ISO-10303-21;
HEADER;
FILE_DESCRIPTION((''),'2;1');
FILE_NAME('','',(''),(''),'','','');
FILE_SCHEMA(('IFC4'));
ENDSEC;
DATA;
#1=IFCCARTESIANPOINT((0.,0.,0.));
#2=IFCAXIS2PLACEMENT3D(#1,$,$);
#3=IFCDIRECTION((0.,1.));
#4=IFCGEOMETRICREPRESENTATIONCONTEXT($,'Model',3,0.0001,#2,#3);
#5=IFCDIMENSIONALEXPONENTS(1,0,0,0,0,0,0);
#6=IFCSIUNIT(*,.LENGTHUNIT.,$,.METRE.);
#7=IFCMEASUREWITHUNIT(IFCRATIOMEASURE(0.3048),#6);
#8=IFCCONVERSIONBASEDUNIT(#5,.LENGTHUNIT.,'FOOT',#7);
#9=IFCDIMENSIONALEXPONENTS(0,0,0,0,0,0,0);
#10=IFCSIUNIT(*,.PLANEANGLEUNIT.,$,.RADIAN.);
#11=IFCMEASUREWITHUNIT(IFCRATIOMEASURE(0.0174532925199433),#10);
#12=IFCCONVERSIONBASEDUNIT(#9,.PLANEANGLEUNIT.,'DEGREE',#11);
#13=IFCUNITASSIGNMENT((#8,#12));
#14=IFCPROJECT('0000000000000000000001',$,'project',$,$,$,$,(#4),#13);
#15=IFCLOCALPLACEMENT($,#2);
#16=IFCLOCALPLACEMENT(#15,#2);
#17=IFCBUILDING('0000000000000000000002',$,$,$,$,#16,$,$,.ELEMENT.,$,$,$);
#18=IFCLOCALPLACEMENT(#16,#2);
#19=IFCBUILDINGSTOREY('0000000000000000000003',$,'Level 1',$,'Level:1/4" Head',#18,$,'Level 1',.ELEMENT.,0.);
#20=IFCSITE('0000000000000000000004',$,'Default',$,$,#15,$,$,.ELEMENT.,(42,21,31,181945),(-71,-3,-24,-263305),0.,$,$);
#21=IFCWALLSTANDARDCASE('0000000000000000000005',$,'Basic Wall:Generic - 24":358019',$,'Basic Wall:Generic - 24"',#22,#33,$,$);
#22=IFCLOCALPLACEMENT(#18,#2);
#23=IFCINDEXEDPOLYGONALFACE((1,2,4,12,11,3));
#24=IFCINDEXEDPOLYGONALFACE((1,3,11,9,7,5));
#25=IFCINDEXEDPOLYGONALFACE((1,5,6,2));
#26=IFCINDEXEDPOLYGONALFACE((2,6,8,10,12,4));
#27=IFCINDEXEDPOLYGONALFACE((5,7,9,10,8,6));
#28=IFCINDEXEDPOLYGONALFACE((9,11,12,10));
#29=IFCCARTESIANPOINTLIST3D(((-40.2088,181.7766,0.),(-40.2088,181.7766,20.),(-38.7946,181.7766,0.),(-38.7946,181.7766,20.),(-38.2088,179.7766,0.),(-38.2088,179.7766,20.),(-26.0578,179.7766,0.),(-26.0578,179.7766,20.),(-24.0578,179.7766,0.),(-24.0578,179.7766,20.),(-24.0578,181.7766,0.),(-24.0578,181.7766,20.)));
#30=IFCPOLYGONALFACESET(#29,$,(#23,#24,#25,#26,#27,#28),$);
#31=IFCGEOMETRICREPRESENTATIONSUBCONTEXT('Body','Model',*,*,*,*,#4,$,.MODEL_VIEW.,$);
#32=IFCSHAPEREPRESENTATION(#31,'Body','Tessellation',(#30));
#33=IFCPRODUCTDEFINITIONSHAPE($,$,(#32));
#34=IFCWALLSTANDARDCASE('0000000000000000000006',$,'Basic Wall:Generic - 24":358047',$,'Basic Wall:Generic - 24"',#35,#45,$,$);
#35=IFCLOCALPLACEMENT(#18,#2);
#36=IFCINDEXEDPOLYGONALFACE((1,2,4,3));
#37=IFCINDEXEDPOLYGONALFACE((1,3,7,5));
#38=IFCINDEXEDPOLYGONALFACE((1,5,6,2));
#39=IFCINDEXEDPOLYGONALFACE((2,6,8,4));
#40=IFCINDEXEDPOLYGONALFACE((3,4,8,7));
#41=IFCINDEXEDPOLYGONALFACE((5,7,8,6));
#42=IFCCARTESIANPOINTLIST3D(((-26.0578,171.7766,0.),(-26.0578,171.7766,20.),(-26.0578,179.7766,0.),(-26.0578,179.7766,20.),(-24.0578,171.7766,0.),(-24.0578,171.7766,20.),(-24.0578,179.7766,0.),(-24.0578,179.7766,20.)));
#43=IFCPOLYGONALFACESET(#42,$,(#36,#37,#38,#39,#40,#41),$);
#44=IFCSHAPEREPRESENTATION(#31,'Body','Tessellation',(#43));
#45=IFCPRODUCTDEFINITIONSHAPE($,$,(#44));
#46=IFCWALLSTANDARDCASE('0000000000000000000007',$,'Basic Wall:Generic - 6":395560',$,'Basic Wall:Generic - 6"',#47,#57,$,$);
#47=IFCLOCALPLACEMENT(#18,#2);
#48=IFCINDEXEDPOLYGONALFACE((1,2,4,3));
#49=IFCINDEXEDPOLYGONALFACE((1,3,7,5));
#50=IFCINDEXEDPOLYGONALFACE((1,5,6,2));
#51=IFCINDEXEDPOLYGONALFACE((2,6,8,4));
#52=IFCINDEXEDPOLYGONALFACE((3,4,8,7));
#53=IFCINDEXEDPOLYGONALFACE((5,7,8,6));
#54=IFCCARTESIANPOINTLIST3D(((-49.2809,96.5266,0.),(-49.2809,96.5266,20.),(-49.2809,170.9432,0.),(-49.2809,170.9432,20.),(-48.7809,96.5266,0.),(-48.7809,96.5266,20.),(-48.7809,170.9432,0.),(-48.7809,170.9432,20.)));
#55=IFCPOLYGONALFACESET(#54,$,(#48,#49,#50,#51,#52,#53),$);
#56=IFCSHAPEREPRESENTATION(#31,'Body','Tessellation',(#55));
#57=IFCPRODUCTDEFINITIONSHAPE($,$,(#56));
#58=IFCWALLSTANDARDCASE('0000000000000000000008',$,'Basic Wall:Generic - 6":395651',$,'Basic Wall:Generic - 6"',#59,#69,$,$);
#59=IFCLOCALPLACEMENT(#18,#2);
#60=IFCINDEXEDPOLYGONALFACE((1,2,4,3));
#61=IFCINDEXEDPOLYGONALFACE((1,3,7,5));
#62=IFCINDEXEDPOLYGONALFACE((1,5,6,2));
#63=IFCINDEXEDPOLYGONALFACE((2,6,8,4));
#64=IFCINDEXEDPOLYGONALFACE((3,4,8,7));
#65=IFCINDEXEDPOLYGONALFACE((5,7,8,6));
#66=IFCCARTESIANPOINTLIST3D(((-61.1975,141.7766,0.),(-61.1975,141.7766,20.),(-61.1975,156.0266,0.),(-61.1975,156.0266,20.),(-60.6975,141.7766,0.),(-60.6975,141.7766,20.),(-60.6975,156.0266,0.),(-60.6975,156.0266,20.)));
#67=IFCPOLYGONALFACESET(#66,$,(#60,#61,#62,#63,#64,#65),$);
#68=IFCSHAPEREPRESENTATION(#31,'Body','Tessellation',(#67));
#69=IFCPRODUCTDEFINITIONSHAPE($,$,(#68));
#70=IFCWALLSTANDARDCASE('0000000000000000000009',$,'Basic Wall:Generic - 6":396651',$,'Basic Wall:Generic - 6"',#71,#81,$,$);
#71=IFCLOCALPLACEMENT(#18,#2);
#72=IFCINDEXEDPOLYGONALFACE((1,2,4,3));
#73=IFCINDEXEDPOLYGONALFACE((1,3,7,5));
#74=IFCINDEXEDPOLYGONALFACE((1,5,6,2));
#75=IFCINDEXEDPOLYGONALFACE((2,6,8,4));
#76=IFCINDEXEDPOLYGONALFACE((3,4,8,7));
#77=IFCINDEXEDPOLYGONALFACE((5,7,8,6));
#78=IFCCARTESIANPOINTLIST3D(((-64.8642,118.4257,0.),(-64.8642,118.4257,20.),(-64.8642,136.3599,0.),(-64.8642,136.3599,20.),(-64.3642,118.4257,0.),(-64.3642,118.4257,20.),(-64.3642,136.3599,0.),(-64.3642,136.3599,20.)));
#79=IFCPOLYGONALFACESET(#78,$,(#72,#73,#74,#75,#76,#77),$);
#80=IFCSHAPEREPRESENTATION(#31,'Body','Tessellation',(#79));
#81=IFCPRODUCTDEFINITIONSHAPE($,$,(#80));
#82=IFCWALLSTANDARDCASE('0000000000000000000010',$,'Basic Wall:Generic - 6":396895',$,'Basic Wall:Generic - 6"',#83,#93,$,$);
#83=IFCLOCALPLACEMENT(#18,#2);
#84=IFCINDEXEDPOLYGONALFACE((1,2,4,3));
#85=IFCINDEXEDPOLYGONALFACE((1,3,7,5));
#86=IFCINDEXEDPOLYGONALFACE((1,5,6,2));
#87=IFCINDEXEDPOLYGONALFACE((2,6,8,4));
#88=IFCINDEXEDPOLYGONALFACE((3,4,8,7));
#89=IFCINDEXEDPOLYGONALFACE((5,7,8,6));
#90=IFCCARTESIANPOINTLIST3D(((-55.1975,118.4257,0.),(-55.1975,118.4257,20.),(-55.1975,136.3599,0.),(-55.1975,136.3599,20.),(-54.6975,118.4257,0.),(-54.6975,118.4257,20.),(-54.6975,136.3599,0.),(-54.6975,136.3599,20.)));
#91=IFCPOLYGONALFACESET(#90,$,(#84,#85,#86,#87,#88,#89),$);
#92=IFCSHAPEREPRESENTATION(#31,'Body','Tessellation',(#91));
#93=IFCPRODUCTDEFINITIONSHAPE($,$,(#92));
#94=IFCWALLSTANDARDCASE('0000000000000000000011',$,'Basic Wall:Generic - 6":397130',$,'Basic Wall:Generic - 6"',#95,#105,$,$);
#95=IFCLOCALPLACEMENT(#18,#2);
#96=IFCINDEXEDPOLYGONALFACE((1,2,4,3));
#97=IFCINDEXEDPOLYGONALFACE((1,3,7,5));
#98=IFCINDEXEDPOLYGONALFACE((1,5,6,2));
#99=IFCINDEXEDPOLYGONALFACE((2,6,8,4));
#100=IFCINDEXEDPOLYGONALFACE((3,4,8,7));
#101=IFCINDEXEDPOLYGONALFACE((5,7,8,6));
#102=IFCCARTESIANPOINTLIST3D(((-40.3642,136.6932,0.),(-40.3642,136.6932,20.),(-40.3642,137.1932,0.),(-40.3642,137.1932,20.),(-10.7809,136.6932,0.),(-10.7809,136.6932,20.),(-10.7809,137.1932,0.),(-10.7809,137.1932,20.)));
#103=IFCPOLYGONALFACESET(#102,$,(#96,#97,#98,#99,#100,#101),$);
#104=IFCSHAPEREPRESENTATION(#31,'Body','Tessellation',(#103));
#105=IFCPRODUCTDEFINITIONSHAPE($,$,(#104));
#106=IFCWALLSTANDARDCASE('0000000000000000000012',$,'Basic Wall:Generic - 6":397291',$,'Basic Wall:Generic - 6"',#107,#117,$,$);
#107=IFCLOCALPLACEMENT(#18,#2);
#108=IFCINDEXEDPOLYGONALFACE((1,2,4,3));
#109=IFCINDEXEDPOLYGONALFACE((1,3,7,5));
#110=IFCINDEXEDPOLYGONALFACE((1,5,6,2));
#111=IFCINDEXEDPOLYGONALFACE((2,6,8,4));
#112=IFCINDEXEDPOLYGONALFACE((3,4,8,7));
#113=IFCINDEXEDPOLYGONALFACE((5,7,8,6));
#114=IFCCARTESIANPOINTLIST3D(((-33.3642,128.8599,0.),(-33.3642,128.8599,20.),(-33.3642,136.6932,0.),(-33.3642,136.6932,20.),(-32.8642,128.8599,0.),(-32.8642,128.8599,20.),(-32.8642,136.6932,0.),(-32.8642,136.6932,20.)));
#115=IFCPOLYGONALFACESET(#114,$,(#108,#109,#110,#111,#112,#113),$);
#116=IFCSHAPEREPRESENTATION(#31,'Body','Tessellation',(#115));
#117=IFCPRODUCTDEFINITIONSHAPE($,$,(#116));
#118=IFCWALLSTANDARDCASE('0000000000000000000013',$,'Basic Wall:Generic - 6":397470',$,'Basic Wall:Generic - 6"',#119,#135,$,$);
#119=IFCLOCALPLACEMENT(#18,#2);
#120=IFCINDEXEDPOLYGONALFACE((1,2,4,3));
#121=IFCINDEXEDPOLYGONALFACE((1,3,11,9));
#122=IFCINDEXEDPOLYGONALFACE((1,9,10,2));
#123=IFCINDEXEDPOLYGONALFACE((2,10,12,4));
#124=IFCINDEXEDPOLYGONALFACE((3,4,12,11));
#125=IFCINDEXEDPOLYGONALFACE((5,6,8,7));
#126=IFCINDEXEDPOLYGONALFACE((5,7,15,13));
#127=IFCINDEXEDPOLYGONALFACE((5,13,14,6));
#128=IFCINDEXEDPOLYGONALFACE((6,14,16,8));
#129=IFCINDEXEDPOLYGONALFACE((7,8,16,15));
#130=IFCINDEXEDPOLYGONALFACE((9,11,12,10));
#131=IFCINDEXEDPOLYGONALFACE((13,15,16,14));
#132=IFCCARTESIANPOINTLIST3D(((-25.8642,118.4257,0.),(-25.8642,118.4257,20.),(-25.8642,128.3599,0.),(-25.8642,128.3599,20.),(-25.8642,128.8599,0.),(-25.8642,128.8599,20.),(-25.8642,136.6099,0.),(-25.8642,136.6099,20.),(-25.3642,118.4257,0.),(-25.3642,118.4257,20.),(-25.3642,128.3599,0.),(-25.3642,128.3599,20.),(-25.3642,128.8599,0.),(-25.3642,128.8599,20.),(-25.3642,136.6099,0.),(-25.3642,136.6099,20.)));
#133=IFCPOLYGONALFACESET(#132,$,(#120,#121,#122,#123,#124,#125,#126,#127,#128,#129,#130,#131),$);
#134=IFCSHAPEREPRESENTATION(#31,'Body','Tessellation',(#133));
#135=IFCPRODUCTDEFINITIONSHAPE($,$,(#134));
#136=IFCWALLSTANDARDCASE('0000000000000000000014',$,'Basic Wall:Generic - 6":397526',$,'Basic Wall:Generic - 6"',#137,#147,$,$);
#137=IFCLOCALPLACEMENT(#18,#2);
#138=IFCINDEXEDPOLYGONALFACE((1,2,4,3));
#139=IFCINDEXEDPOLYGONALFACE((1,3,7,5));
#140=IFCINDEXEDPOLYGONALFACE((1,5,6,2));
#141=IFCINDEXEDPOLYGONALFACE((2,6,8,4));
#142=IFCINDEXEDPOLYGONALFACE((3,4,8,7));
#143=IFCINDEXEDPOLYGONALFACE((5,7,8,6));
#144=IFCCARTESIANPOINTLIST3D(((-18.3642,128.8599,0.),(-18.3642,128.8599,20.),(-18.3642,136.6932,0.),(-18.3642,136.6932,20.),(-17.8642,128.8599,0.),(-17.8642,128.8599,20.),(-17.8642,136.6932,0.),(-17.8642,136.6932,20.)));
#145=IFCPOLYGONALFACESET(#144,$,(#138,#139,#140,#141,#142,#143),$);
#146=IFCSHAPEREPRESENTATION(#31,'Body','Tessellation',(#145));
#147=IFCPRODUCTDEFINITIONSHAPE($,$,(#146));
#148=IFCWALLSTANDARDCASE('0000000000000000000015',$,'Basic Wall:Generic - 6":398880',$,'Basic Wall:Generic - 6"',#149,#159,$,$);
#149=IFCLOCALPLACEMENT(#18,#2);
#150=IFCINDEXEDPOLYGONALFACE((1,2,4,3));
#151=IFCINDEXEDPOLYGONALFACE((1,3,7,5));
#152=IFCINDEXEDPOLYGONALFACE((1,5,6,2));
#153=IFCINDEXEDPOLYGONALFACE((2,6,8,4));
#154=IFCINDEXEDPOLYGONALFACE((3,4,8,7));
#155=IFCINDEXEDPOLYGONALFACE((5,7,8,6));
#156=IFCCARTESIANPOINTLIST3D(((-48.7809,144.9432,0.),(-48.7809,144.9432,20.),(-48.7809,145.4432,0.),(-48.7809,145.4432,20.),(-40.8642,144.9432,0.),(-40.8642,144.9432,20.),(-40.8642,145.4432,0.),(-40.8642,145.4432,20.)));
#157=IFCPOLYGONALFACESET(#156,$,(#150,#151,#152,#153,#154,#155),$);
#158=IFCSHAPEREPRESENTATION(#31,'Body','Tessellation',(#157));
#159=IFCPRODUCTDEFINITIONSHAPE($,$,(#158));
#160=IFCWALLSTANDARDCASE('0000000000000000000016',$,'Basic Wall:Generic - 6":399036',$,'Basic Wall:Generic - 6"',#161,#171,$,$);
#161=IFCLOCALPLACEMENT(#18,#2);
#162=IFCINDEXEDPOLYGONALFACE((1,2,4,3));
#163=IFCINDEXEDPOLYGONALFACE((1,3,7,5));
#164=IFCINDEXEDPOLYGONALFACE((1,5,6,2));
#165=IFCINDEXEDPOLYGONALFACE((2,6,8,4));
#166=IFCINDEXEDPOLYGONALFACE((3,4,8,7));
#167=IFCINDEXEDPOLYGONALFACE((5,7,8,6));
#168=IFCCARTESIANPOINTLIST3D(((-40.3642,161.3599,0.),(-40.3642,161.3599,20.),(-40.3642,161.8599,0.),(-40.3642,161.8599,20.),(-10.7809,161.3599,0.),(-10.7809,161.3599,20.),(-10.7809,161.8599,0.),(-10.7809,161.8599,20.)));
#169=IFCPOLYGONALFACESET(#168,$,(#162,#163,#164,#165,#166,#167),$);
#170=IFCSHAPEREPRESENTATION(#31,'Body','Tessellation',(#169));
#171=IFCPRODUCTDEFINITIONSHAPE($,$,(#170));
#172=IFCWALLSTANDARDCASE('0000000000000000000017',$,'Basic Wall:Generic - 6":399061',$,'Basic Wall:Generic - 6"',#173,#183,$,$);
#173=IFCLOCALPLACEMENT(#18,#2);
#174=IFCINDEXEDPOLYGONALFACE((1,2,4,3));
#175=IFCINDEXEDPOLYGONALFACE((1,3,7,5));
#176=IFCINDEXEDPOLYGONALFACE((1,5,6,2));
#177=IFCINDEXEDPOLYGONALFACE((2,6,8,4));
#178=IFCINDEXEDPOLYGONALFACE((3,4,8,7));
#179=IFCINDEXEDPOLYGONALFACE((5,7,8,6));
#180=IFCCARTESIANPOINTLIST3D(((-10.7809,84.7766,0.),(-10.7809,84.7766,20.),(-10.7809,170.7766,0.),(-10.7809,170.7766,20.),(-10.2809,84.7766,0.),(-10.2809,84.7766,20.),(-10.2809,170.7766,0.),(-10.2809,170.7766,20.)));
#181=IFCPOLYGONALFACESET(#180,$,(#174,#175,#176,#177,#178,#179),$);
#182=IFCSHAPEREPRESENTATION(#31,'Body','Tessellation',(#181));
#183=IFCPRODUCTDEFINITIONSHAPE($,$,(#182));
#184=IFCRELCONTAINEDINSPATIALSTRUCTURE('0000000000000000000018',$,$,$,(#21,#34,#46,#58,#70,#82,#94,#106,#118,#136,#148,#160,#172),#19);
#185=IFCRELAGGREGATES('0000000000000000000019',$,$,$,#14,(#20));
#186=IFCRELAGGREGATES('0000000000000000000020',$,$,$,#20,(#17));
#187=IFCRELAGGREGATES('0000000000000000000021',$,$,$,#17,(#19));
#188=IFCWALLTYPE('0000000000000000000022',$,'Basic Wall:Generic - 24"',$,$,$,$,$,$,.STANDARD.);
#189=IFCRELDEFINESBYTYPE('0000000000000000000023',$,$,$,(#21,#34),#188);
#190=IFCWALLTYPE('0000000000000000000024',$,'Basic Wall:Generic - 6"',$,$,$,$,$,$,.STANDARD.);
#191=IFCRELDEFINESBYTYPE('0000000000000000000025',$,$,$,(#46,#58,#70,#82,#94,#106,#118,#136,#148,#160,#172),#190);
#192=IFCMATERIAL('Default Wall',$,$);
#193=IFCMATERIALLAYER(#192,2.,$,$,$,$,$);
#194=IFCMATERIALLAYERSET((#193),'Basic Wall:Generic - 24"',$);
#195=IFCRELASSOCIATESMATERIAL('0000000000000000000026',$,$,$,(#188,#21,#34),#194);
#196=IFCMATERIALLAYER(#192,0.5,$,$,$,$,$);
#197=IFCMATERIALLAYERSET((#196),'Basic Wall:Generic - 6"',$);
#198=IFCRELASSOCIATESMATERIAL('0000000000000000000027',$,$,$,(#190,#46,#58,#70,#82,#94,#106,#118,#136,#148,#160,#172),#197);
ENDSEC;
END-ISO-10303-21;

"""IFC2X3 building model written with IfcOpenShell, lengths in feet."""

from ifc_helpers import new_model, entity, si_unit, converted_unit, direction, frame, frame_2d, origin, origin_2d_with_axis, place, context, subcontext, project, spatial, polyline, rectangle, outline, extrude, material, layer, layer_set, layer_usage, type_object, element, save


model = new_model("IFC2X3")

# Units and contexts
model_context = context("Model", 3, precision=0.0001, world=origin(), true_north=direction((0.0, 1.0)))
body_context = subcontext(model_context, "Body", "Model", "MODEL_VIEW")
ifc_project = project(units=[converted_unit("LENGTHUNIT", "FOOT", entity("IfcRatioMeasure", 0.3048), si_unit("LENGTHUNIT", "METRE"), dimensions=[1, 0, 0, 0, 0, 0, 0]), converted_unit("PLANEANGLEUNIT", "DEGREE", entity("IfcRatioMeasure", 0.0174532925199433), si_unit("PLANEANGLEUNIT", "RADIAN"), dimensions=[0, 0, 0, 0, 0, 0, 0])], contexts=[model_context])

# Site, building, storey
site_placement = place(None, origin())
site = spatial("IfcSite", under=ifc_project, at=site_placement, Name="Default", CompositionType="ELEMENT", RefLatitude=(42, 21, 31, 181945), RefLongitude=(-71, -3, -24, -263305), RefElevation=0.0)
building_placement = place(site_placement, origin())
building = spatial("IfcBuilding", under=site, at=building_placement, CompositionType="ELEMENT")
storey_placement = place(building_placement, origin())
storey = spatial("IfcBuildingStorey", under=building, at=storey_placement, Name="Level 1", ObjectType="Level:1/4\" Head", LongName="Level 1", CompositionType="ELEMENT", Elevation=0.0)

# Walls
ifc_material = material(Name="Default Wall")
ifc_layer_1 = layer(ifc_material, 2.0)
ifc_layer_set_1 = layer_set([ifc_layer_1], Name="Basic Wall:Generic - 24\"")
ifc_layer_usage_1 = layer_usage(ifc_layer_set_1, "AXIS2", "NEGATIVE", 1.0)
wall_type_1 = type_object("IfcWallType", Name="Basic Wall:Generic - 24\"", PredefinedType="STANDARD", material=ifc_layer_set_1)
wall_1_placement = place(storey_placement, frame((-40.2088, 180.7766, 0.0)))
element("IfcWallStandardCase", 1, at=wall_1_placement, inside=storey, type_object=wall_type_1, material=ifc_layer_usage_1, Name="Basic Wall:Generic - 24\":358019", ObjectType="Basic Wall:Generic - 24\"", context=body_context, shape_type="SweptSolid", body=[
    extrude(outline(polyline([(16.151, -1.0), (16.151, 1.0), (1.4142, 1.0), (0.0, 1.0), (2.0, -1.0), (14.151, -1.0), (16.151, -1.0)])), origin(), (0.0, 0.0, 1.0), 20.0),
])
ifc_layer_usage_2 = layer_usage(ifc_layer_set_1, "AXIS2", "NEGATIVE", 1.0)
wall_2_placement = place(storey_placement, frame((-25.0578, 179.7766, 0.0), z_axis=(0.0, 0.0, 1.0), x_axis=(0.0, -1.0, 0.0)))
element("IfcWallStandardCase", 2, at=wall_2_placement, inside=storey, type_object=wall_type_1, material=ifc_layer_usage_2, Name="Basic Wall:Generic - 24\":358047", ObjectType="Basic Wall:Generic - 24\"", context=body_context, shape_type="SweptSolid", body=[
    extrude(rectangle(XDim=8.0, YDim=2.0, at=frame_2d((4.0, 0.0), x_axis=(-1.0, 0.0))), origin(), (0.0, 0.0, 1.0), 20.0),
])
ifc_layer_2 = layer(ifc_material, 0.5)
ifc_layer_set_2 = layer_set([ifc_layer_2], Name="Basic Wall:Generic - 6\"")
ifc_layer_usage_3 = layer_usage(ifc_layer_set_2, "AXIS2", "NEGATIVE", 0.25)
wall_type_2 = type_object("IfcWallType", Name="Basic Wall:Generic - 6\"", PredefinedType="STANDARD", material=ifc_layer_set_2)
wall_3_placement = place(storey_placement, frame((-49.0309, 170.9432, 0.0), z_axis=(0.0, 0.0, 1.0), x_axis=(0.0, -1.0, 0.0)))
element("IfcWallStandardCase", 3, at=wall_3_placement, inside=storey, type_object=wall_type_2, material=ifc_layer_usage_3, Name="Basic Wall:Generic - 6\":395560", ObjectType="Basic Wall:Generic - 6\"", context=body_context, shape_type="SweptSolid", body=[
    extrude(rectangle(XDim=74.4167, YDim=0.5, at=frame_2d((37.2083, 0.0), x_axis=(-1.0, 0.0))), origin(), (0.0, 0.0, 1.0), 20.0),
])
ifc_layer_usage_4 = layer_usage(ifc_layer_set_2, "AXIS2", "NEGATIVE", 0.25)
wall_4_placement = place(storey_placement, frame((-60.9475, 156.0266, 0.0), z_axis=(0.0, 0.0, 1.0), x_axis=(0.0, -1.0, 0.0)))
element("IfcWallStandardCase", 4, at=wall_4_placement, inside=storey, type_object=wall_type_2, material=ifc_layer_usage_4, Name="Basic Wall:Generic - 6\":395651", ObjectType="Basic Wall:Generic - 6\"", context=body_context, shape_type="SweptSolid", body=[
    extrude(rectangle(XDim=14.25, YDim=0.5, at=frame_2d((7.125, 0.0), x_axis=(-1.0, 0.0))), origin(), (0.0, 0.0, 1.0), 20.0),
])
ifc_layer_usage_5 = layer_usage(ifc_layer_set_2, "AXIS2", "NEGATIVE", 0.25)
wall_5_placement = place(storey_placement, frame((-64.6142, 136.3599, 0.0), z_axis=(0.0, 0.0, 1.0), x_axis=(0.0, -1.0, 0.0)))
element("IfcWallStandardCase", 5, at=wall_5_placement, inside=storey, type_object=wall_type_2, material=ifc_layer_usage_5, Name="Basic Wall:Generic - 6\":396651", ObjectType="Basic Wall:Generic - 6\"", context=body_context, shape_type="SweptSolid", body=[
    extrude(rectangle(XDim=17.9342, YDim=0.5, at=frame_2d((8.9671, 0.0), x_axis=(-1.0, 0.0))), origin(), (0.0, 0.0, 1.0), 20.0),
])
ifc_layer_usage_6 = layer_usage(ifc_layer_set_2, "AXIS2", "NEGATIVE", 0.25)
wall_6_placement = place(storey_placement, frame((-54.9475, 136.3599, 0.0), z_axis=(0.0, 0.0, 1.0), x_axis=(0.0, -1.0, 0.0)))
element("IfcWallStandardCase", 6, at=wall_6_placement, inside=storey, type_object=wall_type_2, material=ifc_layer_usage_6, Name="Basic Wall:Generic - 6\":396895", ObjectType="Basic Wall:Generic - 6\"", context=body_context, shape_type="SweptSolid", body=[
    extrude(rectangle(XDim=17.9342, YDim=0.5, at=frame_2d((8.9671, 0.0), x_axis=(-1.0, 0.0))), origin(), (0.0, 0.0, 1.0), 20.0),
])
ifc_layer_usage_7 = layer_usage(ifc_layer_set_2, "AXIS2", "NEGATIVE", 0.25)
wall_7_placement = place(storey_placement, frame((-40.3642, 136.9432, 0.0)))
element("IfcWallStandardCase", 7, at=wall_7_placement, inside=storey, type_object=wall_type_2, material=ifc_layer_usage_7, Name="Basic Wall:Generic - 6\":397130", ObjectType="Basic Wall:Generic - 6\"", context=body_context, shape_type="SweptSolid", body=[
    extrude(rectangle(XDim=29.5833, YDim=0.5, at=frame_2d((14.7917, 0.0), x_axis=(-1.0, 0.0))), origin(), (0.0, 0.0, 1.0), 20.0),
])
ifc_layer_usage_8 = layer_usage(ifc_layer_set_2, "AXIS2", "NEGATIVE", 0.25)
wall_8_placement = place(storey_placement, frame((-33.1142, 136.6932, 0.0), z_axis=(0.0, 0.0, 1.0), x_axis=(0.0, -1.0, 0.0)))
element("IfcWallStandardCase", 8, at=wall_8_placement, inside=storey, type_object=wall_type_2, material=ifc_layer_usage_8, Name="Basic Wall:Generic - 6\":397291", ObjectType="Basic Wall:Generic - 6\"", context=body_context, shape_type="SweptSolid", body=[
    extrude(rectangle(XDim=7.8333, YDim=0.5, at=frame_2d((3.9167, 0.0), x_axis=(-1.0, 0.0))), origin(), (0.0, 0.0, 1.0), 20.0),
])

# Wall, opening
ifc_layer_usage_9 = layer_usage(ifc_layer_set_2, "AXIS2", "NEGATIVE", 0.25)
wall_9_placement = place(storey_placement, frame((-25.6142, 136.6099, 0.0), z_axis=(0.0, 0.0, 1.0), x_axis=(0.0, -1.0, 0.0)))
wall_9 = element("IfcWallStandardCase", 9, at=wall_9_placement, inside=storey, type_object=wall_type_2, material=ifc_layer_usage_9, Name="Basic Wall:Generic - 6\":397470", ObjectType="Basic Wall:Generic - 6\"", context=body_context, shape_type="SweptSolid", body=[
    extrude(rectangle(XDim=18.1842, YDim=0.5, at=frame_2d((9.0921, 0.0), x_axis=(-1.0, 0.0))), origin(), (0.0, 0.0, 1.0), 20.0),
])
opening_placement = place(storey_placement, frame((-25.6142, 136.6099, 0.0), z_axis=(0.0, 0.0, 1.0), x_axis=(0.0, -1.0, 0.0)))
element("IfcOpeningElement", 10, at=opening_placement, cuts=wall_9, ObjectType="Opening", context=body_context, shape_type="SweptSolid", body=[
    extrude(rectangle(XDim=20.0, YDim=0.5, at=origin_2d_with_axis()), frame((8.25, 0.0, 10.0), z_axis=(-1.0, 0.0, 0.0), x_axis=(0.0, 0.0, 1.0)), (0.0, 0.0, 1.0), 0.5),
])

# Walls
ifc_layer_usage_10 = layer_usage(ifc_layer_set_2, "AXIS2", "NEGATIVE", 0.25)
wall_10_placement = place(storey_placement, frame((-18.1142, 136.6932, 0.0), z_axis=(0.0, 0.0, 1.0), x_axis=(0.0, -1.0, 0.0)))
element("IfcWallStandardCase", 11, at=wall_10_placement, inside=storey, type_object=wall_type_2, material=ifc_layer_usage_10, Name="Basic Wall:Generic - 6\":397526", ObjectType="Basic Wall:Generic - 6\"", context=body_context, shape_type="SweptSolid", body=[
    extrude(rectangle(XDim=7.8333, YDim=0.5, at=frame_2d((3.9167, 0.0), x_axis=(-1.0, 0.0))), origin(), (0.0, 0.0, 1.0), 20.0),
])
ifc_layer_usage_11 = layer_usage(ifc_layer_set_2, "AXIS2", "NEGATIVE", 0.25)
wall_11_placement = place(storey_placement, frame((-48.7809, 145.1932, 0.0)))
element("IfcWallStandardCase", 12, at=wall_11_placement, inside=storey, type_object=wall_type_2, material=ifc_layer_usage_11, Name="Basic Wall:Generic - 6\":398880", ObjectType="Basic Wall:Generic - 6\"", context=body_context, shape_type="SweptSolid", body=[
    extrude(rectangle(XDim=7.9167, YDim=0.5, at=frame_2d((3.9583, 0.0), x_axis=(-1.0, 0.0))), origin(), (0.0, 0.0, 1.0), 20.0),
])
ifc_layer_usage_12 = layer_usage(ifc_layer_set_2, "AXIS2", "NEGATIVE", 0.25)
wall_12_placement = place(storey_placement, frame((-40.3642, 161.6099, 0.0)))
element("IfcWallStandardCase", 13, at=wall_12_placement, inside=storey, type_object=wall_type_2, material=ifc_layer_usage_12, Name="Basic Wall:Generic - 6\":399036", ObjectType="Basic Wall:Generic - 6\"", context=body_context, shape_type="SweptSolid", body=[
    extrude(rectangle(XDim=29.5833, YDim=0.5, at=frame_2d((14.7917, 0.0), x_axis=(-1.0, 0.0))), origin(), (0.0, 0.0, 1.0), 20.0),
])
ifc_layer_usage_13 = layer_usage(ifc_layer_set_2, "AXIS2", "NEGATIVE", 0.25)
wall_13_placement = place(storey_placement, frame((-10.5309, 170.7766, 0.0), z_axis=(0.0, 0.0, 1.0), x_axis=(0.0, -1.0, 0.0)))
element("IfcWallStandardCase", 14, at=wall_13_placement, inside=storey, type_object=wall_type_2, material=ifc_layer_usage_13, Name="Basic Wall:Generic - 6\":399061", ObjectType="Basic Wall:Generic - 6\"", context=body_context, shape_type="SweptSolid", body=[
    extrude(rectangle(XDim=86.0, YDim=0.5, at=frame_2d((43.0, 0.0), x_axis=(-1.0, 0.0))), origin(), (0.0, 0.0, 1.0), 20.0),
])

save(model, "model.ifc")
